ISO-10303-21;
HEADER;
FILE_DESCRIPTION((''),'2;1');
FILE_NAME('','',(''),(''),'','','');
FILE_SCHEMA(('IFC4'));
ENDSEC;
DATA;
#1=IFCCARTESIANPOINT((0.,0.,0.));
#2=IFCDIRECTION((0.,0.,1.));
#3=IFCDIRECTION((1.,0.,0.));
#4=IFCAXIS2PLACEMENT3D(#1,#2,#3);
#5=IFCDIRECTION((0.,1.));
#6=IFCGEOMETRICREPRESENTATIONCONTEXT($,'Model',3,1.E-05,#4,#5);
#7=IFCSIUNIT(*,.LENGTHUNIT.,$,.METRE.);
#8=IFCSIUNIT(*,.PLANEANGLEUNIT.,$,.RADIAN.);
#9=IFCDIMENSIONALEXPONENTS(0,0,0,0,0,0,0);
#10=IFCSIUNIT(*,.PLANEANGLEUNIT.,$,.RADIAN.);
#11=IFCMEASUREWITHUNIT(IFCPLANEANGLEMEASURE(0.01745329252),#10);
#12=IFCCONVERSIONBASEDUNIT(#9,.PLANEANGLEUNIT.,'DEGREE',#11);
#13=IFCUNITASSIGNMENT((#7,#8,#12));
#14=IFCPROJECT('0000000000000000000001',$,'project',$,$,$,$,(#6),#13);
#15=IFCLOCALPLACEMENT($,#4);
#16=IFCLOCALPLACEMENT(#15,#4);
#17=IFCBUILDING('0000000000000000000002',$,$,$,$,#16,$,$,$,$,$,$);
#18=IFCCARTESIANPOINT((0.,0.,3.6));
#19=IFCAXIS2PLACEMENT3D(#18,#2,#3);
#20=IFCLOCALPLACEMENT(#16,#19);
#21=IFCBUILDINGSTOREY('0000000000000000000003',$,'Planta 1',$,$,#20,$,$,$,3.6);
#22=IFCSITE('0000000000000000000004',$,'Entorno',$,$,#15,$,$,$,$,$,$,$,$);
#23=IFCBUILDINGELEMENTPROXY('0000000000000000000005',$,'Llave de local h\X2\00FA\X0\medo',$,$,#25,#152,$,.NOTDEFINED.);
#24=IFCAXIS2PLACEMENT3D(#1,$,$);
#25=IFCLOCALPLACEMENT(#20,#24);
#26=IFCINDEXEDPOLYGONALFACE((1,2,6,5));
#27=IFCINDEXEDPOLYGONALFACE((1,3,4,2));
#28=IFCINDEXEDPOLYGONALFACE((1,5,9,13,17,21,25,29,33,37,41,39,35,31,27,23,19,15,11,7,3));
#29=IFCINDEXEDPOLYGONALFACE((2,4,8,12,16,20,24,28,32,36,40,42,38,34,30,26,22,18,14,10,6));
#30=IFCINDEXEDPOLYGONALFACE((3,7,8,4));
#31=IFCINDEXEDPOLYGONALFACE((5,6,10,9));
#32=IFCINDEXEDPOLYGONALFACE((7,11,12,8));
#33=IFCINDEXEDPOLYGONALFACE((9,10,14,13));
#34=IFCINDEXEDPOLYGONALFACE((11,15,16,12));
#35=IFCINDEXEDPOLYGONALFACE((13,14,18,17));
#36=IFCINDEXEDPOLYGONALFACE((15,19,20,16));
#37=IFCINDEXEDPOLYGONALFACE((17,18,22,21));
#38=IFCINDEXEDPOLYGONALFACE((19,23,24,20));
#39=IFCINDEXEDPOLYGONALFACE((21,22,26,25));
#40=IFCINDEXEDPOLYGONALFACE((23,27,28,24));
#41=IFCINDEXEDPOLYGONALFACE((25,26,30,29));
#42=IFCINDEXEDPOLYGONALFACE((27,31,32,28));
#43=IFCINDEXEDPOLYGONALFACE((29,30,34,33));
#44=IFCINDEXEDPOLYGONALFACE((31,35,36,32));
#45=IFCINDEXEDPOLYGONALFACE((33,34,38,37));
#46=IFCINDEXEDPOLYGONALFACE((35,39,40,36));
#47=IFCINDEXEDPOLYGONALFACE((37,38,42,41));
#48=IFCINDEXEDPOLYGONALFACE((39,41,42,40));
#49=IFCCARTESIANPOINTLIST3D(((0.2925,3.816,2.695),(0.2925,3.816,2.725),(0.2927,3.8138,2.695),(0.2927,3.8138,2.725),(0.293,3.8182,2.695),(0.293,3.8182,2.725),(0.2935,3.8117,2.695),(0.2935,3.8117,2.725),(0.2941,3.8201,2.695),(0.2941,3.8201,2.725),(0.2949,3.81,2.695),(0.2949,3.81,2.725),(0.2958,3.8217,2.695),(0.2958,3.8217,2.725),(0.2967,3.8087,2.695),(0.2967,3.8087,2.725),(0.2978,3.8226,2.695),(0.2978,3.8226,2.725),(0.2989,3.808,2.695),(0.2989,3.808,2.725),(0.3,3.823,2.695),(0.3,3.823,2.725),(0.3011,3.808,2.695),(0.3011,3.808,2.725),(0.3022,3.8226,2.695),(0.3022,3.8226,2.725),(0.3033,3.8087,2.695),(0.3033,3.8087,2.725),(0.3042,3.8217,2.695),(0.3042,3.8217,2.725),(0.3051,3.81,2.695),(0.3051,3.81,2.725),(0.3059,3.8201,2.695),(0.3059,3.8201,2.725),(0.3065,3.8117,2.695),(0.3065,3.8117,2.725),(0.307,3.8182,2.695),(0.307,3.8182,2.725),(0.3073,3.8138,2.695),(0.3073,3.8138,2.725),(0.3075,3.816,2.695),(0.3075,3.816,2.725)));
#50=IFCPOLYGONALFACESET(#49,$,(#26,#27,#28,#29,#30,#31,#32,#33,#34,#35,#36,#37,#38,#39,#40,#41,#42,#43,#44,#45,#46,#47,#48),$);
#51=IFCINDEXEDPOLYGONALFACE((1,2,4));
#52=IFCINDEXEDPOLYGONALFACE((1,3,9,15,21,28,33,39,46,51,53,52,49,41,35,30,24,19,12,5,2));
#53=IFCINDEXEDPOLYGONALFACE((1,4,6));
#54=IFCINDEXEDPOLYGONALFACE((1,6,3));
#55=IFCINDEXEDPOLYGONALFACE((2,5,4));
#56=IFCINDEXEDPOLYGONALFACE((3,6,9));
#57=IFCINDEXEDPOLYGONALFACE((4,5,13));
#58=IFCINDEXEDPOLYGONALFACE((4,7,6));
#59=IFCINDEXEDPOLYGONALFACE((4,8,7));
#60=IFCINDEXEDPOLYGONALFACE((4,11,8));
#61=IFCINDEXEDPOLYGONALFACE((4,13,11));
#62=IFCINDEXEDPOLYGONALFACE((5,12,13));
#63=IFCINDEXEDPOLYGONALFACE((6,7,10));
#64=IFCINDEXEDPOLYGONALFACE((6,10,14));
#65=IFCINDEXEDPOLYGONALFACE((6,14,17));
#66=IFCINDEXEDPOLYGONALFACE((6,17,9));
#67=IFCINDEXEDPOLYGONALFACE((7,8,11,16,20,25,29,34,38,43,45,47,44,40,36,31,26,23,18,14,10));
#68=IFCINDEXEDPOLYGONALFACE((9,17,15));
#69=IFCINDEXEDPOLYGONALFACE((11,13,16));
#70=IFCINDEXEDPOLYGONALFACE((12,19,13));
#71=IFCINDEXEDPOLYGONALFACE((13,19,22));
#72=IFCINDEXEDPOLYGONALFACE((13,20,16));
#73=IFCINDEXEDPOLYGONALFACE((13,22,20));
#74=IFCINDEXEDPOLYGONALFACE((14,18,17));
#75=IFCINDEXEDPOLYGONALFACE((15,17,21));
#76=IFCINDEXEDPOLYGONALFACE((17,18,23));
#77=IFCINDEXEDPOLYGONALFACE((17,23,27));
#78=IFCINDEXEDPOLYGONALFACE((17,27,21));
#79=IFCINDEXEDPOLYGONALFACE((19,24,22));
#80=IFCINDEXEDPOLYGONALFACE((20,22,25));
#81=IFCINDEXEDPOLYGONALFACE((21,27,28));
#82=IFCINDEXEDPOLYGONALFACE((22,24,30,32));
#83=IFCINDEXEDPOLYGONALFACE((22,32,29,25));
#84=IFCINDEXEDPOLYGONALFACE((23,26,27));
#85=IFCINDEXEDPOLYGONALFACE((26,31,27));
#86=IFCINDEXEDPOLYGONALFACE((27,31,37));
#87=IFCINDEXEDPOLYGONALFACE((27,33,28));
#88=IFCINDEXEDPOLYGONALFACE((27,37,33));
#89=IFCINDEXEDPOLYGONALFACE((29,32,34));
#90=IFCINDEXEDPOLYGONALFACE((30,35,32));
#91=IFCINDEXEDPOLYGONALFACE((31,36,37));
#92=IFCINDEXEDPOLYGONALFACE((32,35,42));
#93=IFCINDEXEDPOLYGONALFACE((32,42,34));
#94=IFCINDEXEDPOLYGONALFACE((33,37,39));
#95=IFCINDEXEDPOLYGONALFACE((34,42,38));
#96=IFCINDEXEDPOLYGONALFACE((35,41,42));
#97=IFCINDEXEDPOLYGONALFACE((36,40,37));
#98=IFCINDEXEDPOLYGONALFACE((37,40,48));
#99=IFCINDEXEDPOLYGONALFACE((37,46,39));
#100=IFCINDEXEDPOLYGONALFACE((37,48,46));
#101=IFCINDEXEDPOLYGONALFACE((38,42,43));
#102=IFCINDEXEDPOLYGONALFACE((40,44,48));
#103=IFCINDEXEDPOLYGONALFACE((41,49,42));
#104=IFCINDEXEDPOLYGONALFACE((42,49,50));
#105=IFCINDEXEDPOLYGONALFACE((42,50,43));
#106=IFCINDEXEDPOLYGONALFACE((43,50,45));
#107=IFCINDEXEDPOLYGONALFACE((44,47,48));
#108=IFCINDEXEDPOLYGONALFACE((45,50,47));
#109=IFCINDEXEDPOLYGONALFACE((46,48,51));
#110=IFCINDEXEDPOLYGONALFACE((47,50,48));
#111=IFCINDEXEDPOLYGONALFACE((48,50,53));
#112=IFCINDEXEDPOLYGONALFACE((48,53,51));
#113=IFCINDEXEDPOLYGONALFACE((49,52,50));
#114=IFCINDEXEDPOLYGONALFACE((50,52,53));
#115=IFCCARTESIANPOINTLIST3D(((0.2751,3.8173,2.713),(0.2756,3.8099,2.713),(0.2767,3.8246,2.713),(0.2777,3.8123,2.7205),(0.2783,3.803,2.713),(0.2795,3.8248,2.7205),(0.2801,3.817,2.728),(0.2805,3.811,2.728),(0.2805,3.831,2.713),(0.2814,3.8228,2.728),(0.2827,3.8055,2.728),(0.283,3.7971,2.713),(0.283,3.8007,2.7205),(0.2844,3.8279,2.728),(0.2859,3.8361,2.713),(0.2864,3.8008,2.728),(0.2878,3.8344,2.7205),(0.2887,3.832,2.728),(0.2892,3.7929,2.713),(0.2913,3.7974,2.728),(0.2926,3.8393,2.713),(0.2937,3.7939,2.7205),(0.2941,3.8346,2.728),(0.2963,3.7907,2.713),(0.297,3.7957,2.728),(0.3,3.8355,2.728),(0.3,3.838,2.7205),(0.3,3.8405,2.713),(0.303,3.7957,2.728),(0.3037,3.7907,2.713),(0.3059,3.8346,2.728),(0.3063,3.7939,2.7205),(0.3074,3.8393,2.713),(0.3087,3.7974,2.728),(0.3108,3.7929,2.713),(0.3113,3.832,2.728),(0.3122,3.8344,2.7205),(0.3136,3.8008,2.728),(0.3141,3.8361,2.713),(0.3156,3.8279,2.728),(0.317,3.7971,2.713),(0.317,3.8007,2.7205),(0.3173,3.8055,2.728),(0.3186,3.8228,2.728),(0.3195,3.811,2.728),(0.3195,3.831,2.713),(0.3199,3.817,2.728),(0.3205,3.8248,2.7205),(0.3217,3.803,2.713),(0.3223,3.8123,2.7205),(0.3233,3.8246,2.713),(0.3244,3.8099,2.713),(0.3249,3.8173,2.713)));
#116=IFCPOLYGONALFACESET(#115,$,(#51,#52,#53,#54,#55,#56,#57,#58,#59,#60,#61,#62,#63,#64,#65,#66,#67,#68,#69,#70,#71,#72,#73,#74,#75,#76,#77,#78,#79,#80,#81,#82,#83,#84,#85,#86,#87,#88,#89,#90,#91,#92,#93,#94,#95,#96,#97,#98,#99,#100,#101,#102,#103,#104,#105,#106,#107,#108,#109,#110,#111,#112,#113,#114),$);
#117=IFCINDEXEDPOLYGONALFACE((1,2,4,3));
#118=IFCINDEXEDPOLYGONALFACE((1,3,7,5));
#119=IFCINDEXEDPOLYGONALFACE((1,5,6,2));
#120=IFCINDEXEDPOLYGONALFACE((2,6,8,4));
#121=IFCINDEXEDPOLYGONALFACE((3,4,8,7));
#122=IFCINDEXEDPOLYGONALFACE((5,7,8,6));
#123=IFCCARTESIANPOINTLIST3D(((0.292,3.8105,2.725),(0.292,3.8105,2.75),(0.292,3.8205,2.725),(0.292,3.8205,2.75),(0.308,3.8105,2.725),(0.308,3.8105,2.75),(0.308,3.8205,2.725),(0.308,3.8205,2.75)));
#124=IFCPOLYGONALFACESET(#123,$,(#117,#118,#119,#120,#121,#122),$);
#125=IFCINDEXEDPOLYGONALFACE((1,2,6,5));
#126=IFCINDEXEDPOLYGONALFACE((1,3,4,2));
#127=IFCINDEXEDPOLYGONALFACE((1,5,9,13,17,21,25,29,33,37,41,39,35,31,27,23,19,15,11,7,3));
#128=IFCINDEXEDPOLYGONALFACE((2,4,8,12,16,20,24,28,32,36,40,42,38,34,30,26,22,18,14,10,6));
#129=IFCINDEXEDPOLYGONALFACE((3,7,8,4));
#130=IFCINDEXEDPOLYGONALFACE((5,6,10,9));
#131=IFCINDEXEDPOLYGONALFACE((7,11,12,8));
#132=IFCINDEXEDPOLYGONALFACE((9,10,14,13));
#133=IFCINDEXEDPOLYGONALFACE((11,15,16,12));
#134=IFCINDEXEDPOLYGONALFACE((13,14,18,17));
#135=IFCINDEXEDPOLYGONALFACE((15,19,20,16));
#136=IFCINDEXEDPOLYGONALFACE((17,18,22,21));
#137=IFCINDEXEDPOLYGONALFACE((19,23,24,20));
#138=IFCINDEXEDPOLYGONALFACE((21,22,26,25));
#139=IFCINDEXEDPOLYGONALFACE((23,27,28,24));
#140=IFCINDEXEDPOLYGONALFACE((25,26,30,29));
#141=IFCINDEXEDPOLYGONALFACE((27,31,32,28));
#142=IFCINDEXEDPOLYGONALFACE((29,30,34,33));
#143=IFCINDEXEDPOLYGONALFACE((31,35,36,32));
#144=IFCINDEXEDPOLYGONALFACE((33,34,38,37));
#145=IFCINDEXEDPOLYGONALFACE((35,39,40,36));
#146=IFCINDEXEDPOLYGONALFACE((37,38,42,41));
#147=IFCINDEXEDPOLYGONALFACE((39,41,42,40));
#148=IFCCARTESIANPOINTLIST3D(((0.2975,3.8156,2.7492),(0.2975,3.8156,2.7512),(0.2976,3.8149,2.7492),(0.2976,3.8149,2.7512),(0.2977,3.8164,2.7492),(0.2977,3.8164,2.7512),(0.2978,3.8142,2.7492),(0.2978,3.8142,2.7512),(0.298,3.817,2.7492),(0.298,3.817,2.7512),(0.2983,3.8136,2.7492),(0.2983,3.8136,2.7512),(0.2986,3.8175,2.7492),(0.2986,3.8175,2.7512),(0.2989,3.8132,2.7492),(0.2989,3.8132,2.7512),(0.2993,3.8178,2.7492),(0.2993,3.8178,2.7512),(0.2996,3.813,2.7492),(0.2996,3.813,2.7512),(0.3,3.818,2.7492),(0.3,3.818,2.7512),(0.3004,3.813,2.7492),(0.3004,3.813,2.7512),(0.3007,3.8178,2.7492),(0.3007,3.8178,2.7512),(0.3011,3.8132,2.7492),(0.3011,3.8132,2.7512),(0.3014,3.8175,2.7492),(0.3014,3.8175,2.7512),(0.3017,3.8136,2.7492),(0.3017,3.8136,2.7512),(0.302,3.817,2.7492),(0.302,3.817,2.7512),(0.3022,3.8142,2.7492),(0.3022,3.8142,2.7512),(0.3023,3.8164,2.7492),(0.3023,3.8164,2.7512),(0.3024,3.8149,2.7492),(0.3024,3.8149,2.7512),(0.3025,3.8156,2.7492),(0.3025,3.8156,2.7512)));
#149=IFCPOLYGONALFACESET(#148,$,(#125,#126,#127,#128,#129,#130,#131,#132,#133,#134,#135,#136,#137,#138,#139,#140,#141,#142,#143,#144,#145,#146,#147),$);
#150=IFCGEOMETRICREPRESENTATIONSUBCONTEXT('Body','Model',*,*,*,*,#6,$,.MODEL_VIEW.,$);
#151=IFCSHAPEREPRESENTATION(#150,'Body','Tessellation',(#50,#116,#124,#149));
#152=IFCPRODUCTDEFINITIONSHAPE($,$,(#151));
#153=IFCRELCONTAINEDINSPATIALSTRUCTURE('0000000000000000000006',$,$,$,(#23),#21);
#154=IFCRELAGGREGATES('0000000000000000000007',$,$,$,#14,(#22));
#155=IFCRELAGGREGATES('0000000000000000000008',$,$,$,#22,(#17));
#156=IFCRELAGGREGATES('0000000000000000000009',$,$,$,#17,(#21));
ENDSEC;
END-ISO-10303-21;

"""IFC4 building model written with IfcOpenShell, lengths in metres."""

from ifc_helpers import new_model, entity, si_unit, converted_unit, direction, frame, origin_with_axes, place, context, subcontext, project, spatial, polyline, outline, extrude, element, save


model = new_model("IFC4")

# Units and contexts
model_context = context("Model", 3, precision=1e-05, world=origin_with_axes(), true_north=direction((0.0, 1.0)))
body_context = subcontext(model_context, "Body", "Model", "MODEL_VIEW")
ifc_project = project(units=[si_unit("LENGTHUNIT", "METRE"), si_unit("PLANEANGLEUNIT", "RADIAN"), converted_unit("PLANEANGLEUNIT", "DEGREE", entity("IfcPlaneAngleMeasure", 0.01745329252), si_unit("PLANEANGLEUNIT", "RADIAN"), dimensions=[0, 0, 0, 0, 0, 0, 0])], contexts=[model_context])

# Site, building, storey
site_placement = place(None, origin_with_axes())
site = spatial("IfcSite", under=ifc_project, at=site_placement, Name="Entorno")
building_placement = place(site_placement, origin_with_axes())
building = spatial("IfcBuilding", under=site, at=building_placement)
storey_placement = place(building_placement, frame((0.0, 0.0, 3.6), z_axis=(0.0, 0.0, 1.0), x_axis=(1.0, 0.0, 0.0)))
storey = spatial("IfcBuildingStorey", under=building, at=storey_placement, Name="Planta 1", Elevation=3.6)

# Building element proxy
proxy_1_placement = place(storey_placement, frame((0.0, 0.0, -3.6), z_axis=(0.0, 0.0, 1.0), x_axis=(1.0, 0.0, 0.0)))
ifc_direction_1 = entity("IfcDirection", [0.0, 0.0, 1.0])
ifc_direction_2 = entity("IfcDirection", [0.0, 0.0, 1.0])
ifc_direction_3 = entity("IfcDirection", [0.0, 0.0, 1.0])
element("IfcBuildingElementProxy", 1, at=proxy_1_placement, inside=storey, Name="Llave de local húmedo", PredefinedType="NOTDEFINED", context=body_context, shape_type="Brep", body=[
    entity("IfcExtrudedAreaSolidTapered", entity("IfcCircleProfileDef", "AREA", None, entity("IfcAxis2Placement2D", entity("IfcCartesianPoint", [0.0, 0.0]), entity("IfcDirection", [1.0, 0.0])), 0.0075), entity("IfcAxis2Placement3D", entity("IfcCartesianPoint", [0.3, 3.8155, 6.295]), ifc_direction_1, entity("IfcDirection", [0.0, 1.0, 0.0])), ifc_direction_1, 0.03, entity("IfcCircleProfileDef", "AREA", None, entity("IfcAxis2Placement2D", entity("IfcCartesianPoint", [0.0, 0.0]), entity("IfcDirection", [1.0, 0.0])), 0.0075)),
    entity("IfcExtrudedAreaSolidTapered", entity("IfcCircleProfileDef", "AREA", None, entity("IfcAxis2Placement2D", entity("IfcCartesianPoint", [0.0, 0.0]), entity("IfcDirection", [1.0, 0.0])), 0.025), entity("IfcAxis2Placement3D", entity("IfcCartesianPoint", [0.3, 3.8155, 6.313]), ifc_direction_2, entity("IfcDirection", [0.0, 1.0, 0.0])), ifc_direction_2, 0.015, entity("IfcCircleProfileDef", "AREA", None, entity("IfcAxis2Placement2D", entity("IfcCartesianPoint", [0.0, 0.0]), entity("IfcDirection", [1.0, 0.0])), 0.02)),
    extrude(outline(polyline([(0.005, -0.008), (0.005, 0.008), (-0.005, 0.008), (-0.005, -0.008), (0.005, -0.008)])), frame((0.3, 3.8155, 6.325), z_axis=(0.0, 0.0, 1.0), x_axis=(0.0, 1.0, 0.0)), (0.0, 0.0, 1.0), 0.025),
    entity("IfcExtrudedAreaSolidTapered", entity("IfcCircleProfileDef", "AREA", None, entity("IfcAxis2Placement2D", entity("IfcCartesianPoint", [0.0, 0.0]), entity("IfcDirection", [1.0, 0.0])), 0.0025), entity("IfcAxis2Placement3D", entity("IfcCartesianPoint", [0.3, 3.8155, 6.3492]), ifc_direction_3, entity("IfcDirection", [0.0, 1.0, 0.0])), ifc_direction_3, 0.002, entity("IfcCircleProfileDef", "AREA", None, entity("IfcAxis2Placement2D", entity("IfcCartesianPoint", [0.0, 0.0]), entity("IfcDirection", [1.0, 0.0])), 0.0025)),
])

save(model, "model.ifc")
